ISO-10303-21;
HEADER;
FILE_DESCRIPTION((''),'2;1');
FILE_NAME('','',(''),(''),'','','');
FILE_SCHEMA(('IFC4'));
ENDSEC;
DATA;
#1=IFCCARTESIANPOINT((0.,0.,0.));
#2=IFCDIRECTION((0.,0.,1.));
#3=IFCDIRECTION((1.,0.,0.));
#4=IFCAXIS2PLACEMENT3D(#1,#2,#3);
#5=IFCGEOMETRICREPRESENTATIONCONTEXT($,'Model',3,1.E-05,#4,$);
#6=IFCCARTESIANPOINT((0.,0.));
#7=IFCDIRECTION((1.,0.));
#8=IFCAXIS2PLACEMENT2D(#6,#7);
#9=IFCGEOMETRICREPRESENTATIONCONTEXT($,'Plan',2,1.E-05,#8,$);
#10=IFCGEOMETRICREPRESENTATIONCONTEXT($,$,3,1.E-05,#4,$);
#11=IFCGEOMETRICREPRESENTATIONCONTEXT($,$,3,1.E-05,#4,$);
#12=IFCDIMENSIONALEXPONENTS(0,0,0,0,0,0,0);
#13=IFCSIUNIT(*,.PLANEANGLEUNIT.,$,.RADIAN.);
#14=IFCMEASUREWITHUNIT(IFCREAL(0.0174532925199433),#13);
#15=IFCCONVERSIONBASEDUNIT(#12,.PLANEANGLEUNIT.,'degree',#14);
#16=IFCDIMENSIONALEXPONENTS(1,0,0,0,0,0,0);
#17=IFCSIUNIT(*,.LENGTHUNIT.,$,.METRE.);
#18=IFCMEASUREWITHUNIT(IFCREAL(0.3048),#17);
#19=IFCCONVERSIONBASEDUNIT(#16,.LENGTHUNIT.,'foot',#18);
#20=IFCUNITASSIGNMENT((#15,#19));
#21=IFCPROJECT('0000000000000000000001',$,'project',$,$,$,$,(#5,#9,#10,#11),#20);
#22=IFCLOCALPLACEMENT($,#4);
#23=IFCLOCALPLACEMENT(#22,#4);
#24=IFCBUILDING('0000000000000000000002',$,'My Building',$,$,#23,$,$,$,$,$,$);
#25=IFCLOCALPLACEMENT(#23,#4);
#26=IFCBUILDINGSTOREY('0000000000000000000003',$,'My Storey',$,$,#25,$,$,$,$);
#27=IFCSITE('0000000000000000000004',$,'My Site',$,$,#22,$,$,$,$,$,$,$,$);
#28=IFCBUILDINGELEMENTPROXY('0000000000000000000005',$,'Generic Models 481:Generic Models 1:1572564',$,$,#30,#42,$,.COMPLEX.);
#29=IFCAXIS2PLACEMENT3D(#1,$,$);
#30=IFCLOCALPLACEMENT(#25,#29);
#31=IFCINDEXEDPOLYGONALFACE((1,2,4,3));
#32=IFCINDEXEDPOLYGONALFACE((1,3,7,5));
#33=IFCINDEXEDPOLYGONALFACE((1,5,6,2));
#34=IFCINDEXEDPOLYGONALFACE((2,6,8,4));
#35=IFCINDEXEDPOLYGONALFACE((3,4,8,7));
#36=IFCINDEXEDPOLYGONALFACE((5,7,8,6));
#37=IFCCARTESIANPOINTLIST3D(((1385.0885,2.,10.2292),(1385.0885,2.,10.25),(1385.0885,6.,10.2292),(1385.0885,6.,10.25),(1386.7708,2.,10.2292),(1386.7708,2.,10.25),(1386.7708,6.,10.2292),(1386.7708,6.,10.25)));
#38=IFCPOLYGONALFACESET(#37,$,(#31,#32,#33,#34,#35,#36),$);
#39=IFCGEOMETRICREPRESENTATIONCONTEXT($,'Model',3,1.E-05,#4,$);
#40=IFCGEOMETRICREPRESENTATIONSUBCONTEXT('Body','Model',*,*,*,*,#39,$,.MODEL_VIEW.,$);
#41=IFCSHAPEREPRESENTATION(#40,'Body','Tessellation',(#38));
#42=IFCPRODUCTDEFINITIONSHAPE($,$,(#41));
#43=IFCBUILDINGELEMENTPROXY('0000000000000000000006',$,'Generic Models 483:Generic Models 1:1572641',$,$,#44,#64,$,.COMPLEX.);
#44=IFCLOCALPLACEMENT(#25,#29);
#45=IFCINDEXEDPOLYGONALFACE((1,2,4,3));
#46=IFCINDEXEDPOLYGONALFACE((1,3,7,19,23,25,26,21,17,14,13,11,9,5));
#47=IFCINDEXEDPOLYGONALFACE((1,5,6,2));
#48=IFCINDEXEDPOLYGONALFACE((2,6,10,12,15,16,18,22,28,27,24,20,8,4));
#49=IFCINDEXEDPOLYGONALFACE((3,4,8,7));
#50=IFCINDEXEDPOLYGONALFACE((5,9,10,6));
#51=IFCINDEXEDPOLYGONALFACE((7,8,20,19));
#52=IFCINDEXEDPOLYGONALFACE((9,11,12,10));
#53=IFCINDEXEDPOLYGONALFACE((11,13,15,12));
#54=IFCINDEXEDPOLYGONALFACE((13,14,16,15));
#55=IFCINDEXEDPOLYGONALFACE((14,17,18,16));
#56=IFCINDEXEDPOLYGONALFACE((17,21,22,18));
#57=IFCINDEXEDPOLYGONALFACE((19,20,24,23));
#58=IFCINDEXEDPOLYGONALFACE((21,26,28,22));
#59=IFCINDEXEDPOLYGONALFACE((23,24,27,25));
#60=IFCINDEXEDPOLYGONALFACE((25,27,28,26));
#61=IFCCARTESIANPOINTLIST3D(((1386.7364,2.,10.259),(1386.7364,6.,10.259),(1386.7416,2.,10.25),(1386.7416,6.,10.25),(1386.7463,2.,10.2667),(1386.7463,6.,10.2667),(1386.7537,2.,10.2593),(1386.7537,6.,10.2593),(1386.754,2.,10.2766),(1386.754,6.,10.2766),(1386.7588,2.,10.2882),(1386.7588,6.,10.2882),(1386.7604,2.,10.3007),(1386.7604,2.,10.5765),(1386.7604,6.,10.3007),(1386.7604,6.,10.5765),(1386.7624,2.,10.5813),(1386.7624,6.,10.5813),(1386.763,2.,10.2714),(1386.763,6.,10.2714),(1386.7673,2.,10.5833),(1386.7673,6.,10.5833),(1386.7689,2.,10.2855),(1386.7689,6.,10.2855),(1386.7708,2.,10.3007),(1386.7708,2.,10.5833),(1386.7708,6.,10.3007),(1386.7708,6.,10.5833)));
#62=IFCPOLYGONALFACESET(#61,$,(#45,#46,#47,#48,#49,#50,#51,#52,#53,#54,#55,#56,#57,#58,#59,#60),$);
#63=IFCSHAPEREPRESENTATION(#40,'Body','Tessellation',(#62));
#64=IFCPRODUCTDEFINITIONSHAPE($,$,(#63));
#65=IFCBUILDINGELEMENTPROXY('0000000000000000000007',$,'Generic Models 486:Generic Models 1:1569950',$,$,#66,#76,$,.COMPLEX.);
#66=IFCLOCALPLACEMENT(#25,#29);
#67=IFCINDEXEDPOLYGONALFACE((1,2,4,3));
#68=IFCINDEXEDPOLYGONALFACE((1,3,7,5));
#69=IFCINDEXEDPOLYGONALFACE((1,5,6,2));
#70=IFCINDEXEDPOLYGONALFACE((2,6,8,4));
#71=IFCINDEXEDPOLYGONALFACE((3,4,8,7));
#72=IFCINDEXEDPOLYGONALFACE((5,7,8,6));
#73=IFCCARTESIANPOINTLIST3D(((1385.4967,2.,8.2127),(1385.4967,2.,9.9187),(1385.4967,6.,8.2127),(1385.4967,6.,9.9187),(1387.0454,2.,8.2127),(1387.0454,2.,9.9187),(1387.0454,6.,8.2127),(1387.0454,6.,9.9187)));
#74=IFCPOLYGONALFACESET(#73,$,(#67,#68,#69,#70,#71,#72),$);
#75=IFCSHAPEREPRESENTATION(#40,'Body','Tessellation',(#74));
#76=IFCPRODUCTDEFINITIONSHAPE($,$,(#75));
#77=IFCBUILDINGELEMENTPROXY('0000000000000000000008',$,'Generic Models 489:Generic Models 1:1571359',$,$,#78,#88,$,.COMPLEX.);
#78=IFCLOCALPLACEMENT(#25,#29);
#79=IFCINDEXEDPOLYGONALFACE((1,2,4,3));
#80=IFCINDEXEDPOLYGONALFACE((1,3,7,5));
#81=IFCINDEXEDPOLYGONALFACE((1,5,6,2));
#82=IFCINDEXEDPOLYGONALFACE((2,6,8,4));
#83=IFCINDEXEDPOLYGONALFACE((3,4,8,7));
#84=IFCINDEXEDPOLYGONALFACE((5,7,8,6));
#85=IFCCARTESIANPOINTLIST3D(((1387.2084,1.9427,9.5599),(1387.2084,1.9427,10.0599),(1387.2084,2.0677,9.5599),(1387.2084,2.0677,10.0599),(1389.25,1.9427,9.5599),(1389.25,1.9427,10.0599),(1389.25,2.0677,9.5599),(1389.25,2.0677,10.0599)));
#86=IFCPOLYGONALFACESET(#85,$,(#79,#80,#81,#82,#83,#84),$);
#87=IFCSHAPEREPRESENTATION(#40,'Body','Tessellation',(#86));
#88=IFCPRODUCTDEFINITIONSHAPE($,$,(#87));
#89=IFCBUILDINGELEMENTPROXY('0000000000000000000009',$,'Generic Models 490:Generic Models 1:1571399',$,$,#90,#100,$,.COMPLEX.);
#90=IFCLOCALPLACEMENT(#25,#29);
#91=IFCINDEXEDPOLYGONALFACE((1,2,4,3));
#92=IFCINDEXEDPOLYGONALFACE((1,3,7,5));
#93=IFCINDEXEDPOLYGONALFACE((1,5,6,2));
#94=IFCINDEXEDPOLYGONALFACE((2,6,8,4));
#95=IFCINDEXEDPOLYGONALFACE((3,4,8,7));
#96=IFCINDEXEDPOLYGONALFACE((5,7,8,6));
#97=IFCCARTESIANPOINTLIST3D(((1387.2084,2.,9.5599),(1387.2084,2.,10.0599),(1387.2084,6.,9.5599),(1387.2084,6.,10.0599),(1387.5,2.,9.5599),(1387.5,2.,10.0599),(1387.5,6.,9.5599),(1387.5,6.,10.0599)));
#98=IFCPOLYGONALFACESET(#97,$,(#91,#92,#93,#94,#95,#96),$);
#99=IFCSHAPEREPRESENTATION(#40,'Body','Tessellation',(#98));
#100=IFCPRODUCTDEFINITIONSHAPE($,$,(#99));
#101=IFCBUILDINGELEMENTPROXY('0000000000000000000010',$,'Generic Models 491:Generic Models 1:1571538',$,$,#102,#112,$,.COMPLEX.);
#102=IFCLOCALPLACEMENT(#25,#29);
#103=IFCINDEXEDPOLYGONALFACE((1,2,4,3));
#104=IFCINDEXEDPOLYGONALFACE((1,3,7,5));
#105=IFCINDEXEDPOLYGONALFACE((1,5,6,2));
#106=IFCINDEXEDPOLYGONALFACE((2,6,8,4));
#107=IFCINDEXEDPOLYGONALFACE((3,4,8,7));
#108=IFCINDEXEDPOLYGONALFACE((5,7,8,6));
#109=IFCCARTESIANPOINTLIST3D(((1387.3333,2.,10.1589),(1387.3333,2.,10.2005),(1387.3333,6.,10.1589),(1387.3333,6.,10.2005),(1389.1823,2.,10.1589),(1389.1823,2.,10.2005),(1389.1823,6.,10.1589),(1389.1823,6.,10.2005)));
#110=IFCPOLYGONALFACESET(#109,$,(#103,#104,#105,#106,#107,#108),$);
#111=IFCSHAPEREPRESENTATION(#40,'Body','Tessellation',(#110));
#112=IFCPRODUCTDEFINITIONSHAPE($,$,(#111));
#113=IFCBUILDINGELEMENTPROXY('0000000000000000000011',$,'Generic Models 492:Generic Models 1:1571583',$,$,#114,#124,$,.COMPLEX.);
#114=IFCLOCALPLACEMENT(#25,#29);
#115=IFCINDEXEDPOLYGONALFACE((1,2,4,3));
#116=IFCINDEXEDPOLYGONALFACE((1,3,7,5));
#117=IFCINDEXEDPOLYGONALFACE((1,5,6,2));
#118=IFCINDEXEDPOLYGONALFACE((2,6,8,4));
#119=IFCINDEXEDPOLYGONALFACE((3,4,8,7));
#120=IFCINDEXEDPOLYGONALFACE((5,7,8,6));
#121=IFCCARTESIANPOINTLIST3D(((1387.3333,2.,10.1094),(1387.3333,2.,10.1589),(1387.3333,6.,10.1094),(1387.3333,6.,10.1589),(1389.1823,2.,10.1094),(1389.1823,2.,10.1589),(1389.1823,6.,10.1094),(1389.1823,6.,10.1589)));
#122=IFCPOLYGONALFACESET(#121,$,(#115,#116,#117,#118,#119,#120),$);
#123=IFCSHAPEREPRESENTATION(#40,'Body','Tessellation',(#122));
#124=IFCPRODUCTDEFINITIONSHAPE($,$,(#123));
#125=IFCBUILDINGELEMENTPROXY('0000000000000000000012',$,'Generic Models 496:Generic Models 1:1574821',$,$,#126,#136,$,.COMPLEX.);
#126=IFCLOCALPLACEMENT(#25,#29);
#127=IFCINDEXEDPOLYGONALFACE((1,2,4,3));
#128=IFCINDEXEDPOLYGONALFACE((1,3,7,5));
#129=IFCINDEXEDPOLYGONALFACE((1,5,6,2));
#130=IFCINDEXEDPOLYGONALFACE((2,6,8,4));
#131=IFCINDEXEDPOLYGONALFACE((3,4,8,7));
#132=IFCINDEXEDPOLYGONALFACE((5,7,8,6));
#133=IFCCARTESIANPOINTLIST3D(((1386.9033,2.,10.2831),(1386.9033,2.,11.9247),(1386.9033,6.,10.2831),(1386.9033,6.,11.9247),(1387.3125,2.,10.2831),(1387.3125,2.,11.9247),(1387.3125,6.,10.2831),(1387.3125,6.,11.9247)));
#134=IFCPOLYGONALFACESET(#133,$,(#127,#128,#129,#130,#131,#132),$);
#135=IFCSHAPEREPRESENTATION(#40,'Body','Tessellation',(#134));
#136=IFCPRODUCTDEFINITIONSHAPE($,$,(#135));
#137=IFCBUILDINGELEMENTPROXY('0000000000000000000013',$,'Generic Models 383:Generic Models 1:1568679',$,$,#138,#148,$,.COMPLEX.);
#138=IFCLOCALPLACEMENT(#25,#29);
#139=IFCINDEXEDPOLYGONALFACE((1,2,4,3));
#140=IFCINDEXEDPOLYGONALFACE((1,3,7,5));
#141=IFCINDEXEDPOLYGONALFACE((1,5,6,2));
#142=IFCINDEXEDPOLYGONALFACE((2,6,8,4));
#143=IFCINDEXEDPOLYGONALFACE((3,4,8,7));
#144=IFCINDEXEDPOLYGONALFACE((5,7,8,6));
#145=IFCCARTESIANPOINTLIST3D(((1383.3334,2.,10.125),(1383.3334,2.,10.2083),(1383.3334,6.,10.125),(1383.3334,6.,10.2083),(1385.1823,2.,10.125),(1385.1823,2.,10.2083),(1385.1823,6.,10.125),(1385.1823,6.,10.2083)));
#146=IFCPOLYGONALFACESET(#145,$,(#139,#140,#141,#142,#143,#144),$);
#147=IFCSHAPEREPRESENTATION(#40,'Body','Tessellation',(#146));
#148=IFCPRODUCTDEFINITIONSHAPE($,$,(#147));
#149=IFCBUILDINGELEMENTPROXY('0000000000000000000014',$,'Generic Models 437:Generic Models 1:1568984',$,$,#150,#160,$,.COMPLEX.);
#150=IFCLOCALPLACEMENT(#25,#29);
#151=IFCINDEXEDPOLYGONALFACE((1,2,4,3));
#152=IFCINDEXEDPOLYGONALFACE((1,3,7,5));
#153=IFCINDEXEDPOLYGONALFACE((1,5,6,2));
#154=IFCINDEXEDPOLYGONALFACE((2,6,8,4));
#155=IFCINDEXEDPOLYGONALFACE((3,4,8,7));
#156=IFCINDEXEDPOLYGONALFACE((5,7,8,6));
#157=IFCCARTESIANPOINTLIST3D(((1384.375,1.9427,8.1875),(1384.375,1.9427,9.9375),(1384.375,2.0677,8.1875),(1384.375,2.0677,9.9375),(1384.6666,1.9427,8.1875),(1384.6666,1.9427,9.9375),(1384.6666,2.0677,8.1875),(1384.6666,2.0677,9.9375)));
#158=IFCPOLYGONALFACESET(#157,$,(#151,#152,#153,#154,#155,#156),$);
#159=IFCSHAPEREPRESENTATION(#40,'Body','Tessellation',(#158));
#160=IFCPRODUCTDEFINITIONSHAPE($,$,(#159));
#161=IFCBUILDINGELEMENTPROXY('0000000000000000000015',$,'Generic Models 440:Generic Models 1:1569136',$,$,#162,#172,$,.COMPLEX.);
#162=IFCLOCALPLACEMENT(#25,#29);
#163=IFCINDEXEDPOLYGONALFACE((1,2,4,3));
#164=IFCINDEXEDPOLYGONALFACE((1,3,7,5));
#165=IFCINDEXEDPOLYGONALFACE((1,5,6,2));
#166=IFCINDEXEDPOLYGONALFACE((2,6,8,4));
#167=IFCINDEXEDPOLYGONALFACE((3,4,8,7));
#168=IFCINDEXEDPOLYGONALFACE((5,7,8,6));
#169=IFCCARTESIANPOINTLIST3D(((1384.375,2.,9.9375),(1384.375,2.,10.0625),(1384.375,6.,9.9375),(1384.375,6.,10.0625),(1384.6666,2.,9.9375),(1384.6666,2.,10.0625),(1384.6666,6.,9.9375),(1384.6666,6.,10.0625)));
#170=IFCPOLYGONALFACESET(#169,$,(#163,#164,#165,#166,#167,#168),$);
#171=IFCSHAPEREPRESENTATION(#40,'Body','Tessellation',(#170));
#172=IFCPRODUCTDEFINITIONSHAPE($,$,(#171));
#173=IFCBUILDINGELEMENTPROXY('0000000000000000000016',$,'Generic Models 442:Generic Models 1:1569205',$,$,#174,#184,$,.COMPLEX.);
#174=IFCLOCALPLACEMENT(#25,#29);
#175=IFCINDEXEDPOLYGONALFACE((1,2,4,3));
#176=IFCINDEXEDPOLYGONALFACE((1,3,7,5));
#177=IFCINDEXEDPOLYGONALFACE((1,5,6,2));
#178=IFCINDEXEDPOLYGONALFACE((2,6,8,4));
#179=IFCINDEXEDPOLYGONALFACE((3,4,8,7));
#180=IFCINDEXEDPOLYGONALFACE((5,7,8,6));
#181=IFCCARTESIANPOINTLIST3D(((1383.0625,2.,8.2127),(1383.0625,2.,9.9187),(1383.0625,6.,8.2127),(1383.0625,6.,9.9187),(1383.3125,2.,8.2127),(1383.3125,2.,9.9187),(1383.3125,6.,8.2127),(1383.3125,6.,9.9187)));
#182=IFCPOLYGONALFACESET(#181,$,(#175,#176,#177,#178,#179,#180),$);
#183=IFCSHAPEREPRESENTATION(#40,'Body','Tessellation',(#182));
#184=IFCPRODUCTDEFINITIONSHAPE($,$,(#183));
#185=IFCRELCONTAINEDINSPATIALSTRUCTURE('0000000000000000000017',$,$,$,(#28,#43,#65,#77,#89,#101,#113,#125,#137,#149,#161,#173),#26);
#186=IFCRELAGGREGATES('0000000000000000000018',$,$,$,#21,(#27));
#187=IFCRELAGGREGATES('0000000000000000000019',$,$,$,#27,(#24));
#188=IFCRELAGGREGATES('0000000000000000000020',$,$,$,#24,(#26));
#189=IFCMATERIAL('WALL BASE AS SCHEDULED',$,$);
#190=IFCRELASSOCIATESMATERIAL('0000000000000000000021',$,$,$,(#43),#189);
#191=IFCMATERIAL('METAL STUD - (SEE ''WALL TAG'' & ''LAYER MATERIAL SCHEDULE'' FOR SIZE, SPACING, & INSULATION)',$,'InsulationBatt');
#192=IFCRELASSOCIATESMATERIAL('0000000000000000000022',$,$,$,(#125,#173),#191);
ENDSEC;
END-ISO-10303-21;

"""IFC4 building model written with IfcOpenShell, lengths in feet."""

from ifc_helpers import new_model, entity, si_unit, converted_unit, frame, origin_with_axes, origin_2d_with_axis, place, context, subcontext, project, spatial, polyline, outline, extrude, material, element, save


model = new_model("IFC4")

# Units and contexts
model_context_1 = context("Model", 3, precision=1e-05, world=origin_with_axes())
plan_context = context("Plan", 2, precision=1e-05, world=origin_2d_with_axis())
model_context_2 = context("Model", 3, precision=1e-05, world=origin_with_axes())
context_of_model_1 = context(None, 3, precision=1e-05, world=origin_with_axes())
context_of_model_2 = context(None, 3, precision=1e-05, world=origin_with_axes())
body_context = subcontext(model_context_2, "Body", "Model", "MODEL_VIEW")
ifc_project = project(units=[converted_unit("PLANEANGLEUNIT", "degree", entity("IfcReal", 0.0174532925199433), si_unit("PLANEANGLEUNIT", "RADIAN"), dimensions=[0, 0, 0, 0, 0, 0, 0]), converted_unit("LENGTHUNIT", "foot", entity("IfcReal", 0.3048), si_unit("LENGTHUNIT", "METRE"), dimensions=[1, 0, 0, 0, 0, 0, 0])], contexts=[model_context_1, plan_context, context_of_model_1, context_of_model_2])

# Site, building, storey
site_placement = place(None, origin_with_axes())
site = spatial("IfcSite", under=ifc_project, at=site_placement, Name="My Site")
building_placement = place(site_placement, origin_with_axes())
building = spatial("IfcBuilding", under=site, at=building_placement, Name="My Building")
storey_placement = place(building_placement, origin_with_axes())
storey = spatial("IfcBuildingStorey", under=building, at=storey_placement, Name="My Storey")

# Building element proxies
proxy_1_placement = place(storey_placement, frame((1385.0885, 6.0, 10.2292), z_axis=(0.0, -1.0, 0.0), x_axis=(0.0, 0.0, 1.0)))
element("IfcBuildingElementProxy", 1, at=proxy_1_placement, inside=storey, Name="Generic Models 481:Generic Models 1:1572564", PredefinedType="COMPLEX", context=body_context, shape_type="SweptSolid", body=[
    extrude(outline(polyline([(0.8412, 0.0), (0.841, 0.0208), (-0.8412, 0.0), (-0.841, -0.0208), (0.8412, 0.0)])), frame((0.0104, -0.8411, 0.0), z_axis=(0.0, 0.0, -1.0), x_axis=(0.012383, -0.999923, 0.0)), (0.0, 0.0, -1.0), 4.0),
])
ifc_material_1 = material(Name="WALL BASE AS SCHEDULED")
proxy_2_placement = place(storey_placement, frame((1386.7364, 6.0, 10.25), z_axis=(0.0, -1.0, 0.0), x_axis=(0.0, 0.0, 1.0)))
element("IfcBuildingElementProxy", 2, at=proxy_2_placement, inside=storey, material=ifc_material_1, Name="Generic Models 483:Generic Models 1:1572641", PredefinedType="COMPLEX", context=body_context, shape_type="SweptSolid", body=[
    extrude(outline(polyline([(0.2205, 0.0), (0.2206, 0.0036), (-0.0618, 0.0152), (-0.077, 0.0138), (-0.0914, 0.0086), (-0.1038, -0.0002), (-0.1136, -0.012), (-0.1048, -0.0175), (-0.0968, -0.0079), (-0.0865, -0.0007), (-0.0747, 0.0037), (-0.0622, 0.0048), (0.2133, -0.0066), (0.2183, -0.0048), (0.2205, 0.0)])), frame((0.113, -0.0218, 0.0), z_axis=(0.0, 0.0, -1.0), x_axis=(0.999153, -0.041137, 0.0)), (0.0, 0.0, -1.0), 4.0),
])
proxy_3_placement = place(storey_placement, frame((1385.4967, 6.0, 8.2127), z_axis=(0.0, -1.0, 0.0), x_axis=(0.0, 0.0, 1.0)))
element("IfcBuildingElementProxy", 3, at=proxy_3_placement, inside=storey, Name="Generic Models 486:Generic Models 1:1569950", PredefinedType="COMPLEX", context=body_context, shape_type="SweptSolid", body=[
    extrude(outline(polyline([(-0.853, -0.7743), (0.853, -0.7743), (0.853, 0.7743), (-0.853, 0.7743), (-0.853, -0.7743)])), frame((0.853, -0.7743, 0.0), z_axis=(0.0, 0.0, -1.0), x_axis=(-1.0, 0.0, 0.0)), (0.0, 0.0, -1.0), 4.0),
])
proxy_4_placement = place(storey_placement, frame((1387.2084, 1.9427, 9.5599), z_axis=(1.0, 0.0, 0.0), x_axis=(0.0, 0.0, -1.0)))
element("IfcBuildingElementProxy", 4, at=proxy_4_placement, inside=storey, Name="Generic Models 489:Generic Models 1:1571359", PredefinedType="COMPLEX", context=body_context, shape_type="SweptSolid", body=[
    extrude(outline(polyline([(-0.0625, -0.25), (0.0625, -0.25), (0.0625, 0.25), (-0.0625, 0.25), (-0.0625, -0.25)])), frame((-0.25, 0.0625, 0.0), z_axis=(0.0, 0.0, -1.0), x_axis=(0.0, -1.0, 0.0)), (0.0, 0.0, -1.0), 2.0417),
])
proxy_5_placement = place(storey_placement, frame((1387.2084, 6.0, 9.5599), z_axis=(0.0, -1.0, 0.0), x_axis=(0.0, 0.0, 1.0)))
element("IfcBuildingElementProxy", 5, at=proxy_5_placement, inside=storey, Name="Generic Models 490:Generic Models 1:1571399", PredefinedType="COMPLEX", context=body_context, shape_type="SweptSolid", body=[
    extrude(outline(polyline([(-0.25, -0.1458), (0.25, -0.1458), (0.25, 0.1458), (-0.25, 0.1458), (-0.25, -0.1458)])), frame((0.25, -0.1458, 0.0), z_axis=(0.0, 0.0, -1.0), x_axis=(-1.0, 0.0, 0.0)), (0.0, 0.0, -1.0), 4.0),
])
proxy_6_placement = place(storey_placement, frame((1387.3333, 6.0, 10.1589), z_axis=(0.0, -1.0, 0.0), x_axis=(0.0, 0.0, 1.0)))
element("IfcBuildingElementProxy", 6, at=proxy_6_placement, inside=storey, Name="Generic Models 491:Generic Models 1:1571538", PredefinedType="COMPLEX", context=body_context, shape_type="SweptSolid", body=[
    extrude(outline(polyline([(-0.0208, -0.9245), (0.0208, -0.9245), (0.0208, 0.9245), (-0.0208, 0.9245), (-0.0208, -0.9245)])), frame((0.0208, -0.9245, 0.0), z_axis=(0.0, 0.0, -1.0), x_axis=(-1.0, 0.0, 0.0)), (0.0, 0.0, -1.0), 4.0),
])
proxy_7_placement = place(storey_placement, frame((1387.3333, 6.0, 10.1094), z_axis=(0.0, -1.0, 0.0), x_axis=(0.0, 0.0, 1.0)))
element("IfcBuildingElementProxy", 7, at=proxy_7_placement, inside=storey, Name="Generic Models 492:Generic Models 1:1571583", PredefinedType="COMPLEX", context=body_context, shape_type="SweptSolid", body=[
    extrude(outline(polyline([(-0.0247, -0.9245), (0.0247, -0.9245), (0.0247, 0.9245), (-0.0247, 0.9245), (-0.0247, -0.9245)])), frame((0.0247, -0.9245, 0.0), z_axis=(0.0, 0.0, -1.0), x_axis=(-1.0, 0.0, 0.0)), (0.0, 0.0, -1.0), 4.0),
])
ifc_material_2 = material(Name="METAL STUD - (SEE 'WALL TAG' & 'LAYER MATERIAL SCHEDULE' FOR SIZE, SPACING, & INSULATION)", Category="InsulationBatt")
proxy_8_placement = place(storey_placement, frame((1386.9033, 6.0, 10.2831), z_axis=(0.0, -1.0, 0.0), x_axis=(0.0, 0.0, 1.0)))
element("IfcBuildingElementProxy", 8, at=proxy_8_placement, inside=storey, material=ifc_material_2, Name="Generic Models 496:Generic Models 1:1574821", PredefinedType="COMPLEX", context=body_context, shape_type="SweptSolid", body=[
    extrude(outline(polyline([(-0.8208, -0.2046), (0.8208, -0.2046), (0.8208, 0.2046), (-0.8208, 0.2046), (-0.8208, -0.2046)])), frame((0.8208, -0.2046, 0.0), z_axis=(0.0, 0.0, -1.0), x_axis=(1.0, 0.0, 0.0)), (0.0, 0.0, -1.0), 4.0),
])
proxy_9_placement = place(storey_placement, frame((1383.3334, 6.0, 10.125), z_axis=(0.0, -1.0, 0.0), x_axis=(0.0, 0.0, 1.0)))
element("IfcBuildingElementProxy", 9, at=proxy_9_placement, inside=storey, Name="Generic Models 383:Generic Models 1:1568679", PredefinedType="COMPLEX", context=body_context, shape_type="SweptSolid", body=[
    extrude(outline(polyline([(-0.0417, -0.9245), (0.0417, -0.9245), (0.0417, 0.9245), (-0.0417, 0.9245), (-0.0417, -0.9245)])), frame((0.0417, -0.9245, 0.0), z_axis=(0.0, 0.0, -1.0), x_axis=(-1.0, 0.0, 0.0)), (0.0, 0.0, -1.0), 4.0),
])
proxy_10_placement = place(storey_placement, frame((1384.375, 1.9427, 8.1875), z_axis=(0.0, 0.0, 1.0), x_axis=(1.0, 0.0, 0.0)))
element("IfcBuildingElementProxy", 10, at=proxy_10_placement, inside=storey, Name="Generic Models 437:Generic Models 1:1568984", PredefinedType="COMPLEX", context=body_context, shape_type="SweptSolid", body=[
    extrude(outline(polyline([(-0.1458, -0.0625), (0.1458, -0.0625), (0.1458, 0.0625), (-0.1458, 0.0625), (-0.1458, -0.0625)])), frame((0.1458, 0.0625, 0.0), z_axis=(0.0, 0.0, -1.0), x_axis=(-1.0, 0.0, 0.0)), (0.0, 0.0, -1.0), 1.75),
])
proxy_11_placement = place(storey_placement, frame((1384.375, 6.0, 9.9375), z_axis=(0.0, -1.0, 0.0), x_axis=(0.0, 0.0, 1.0)))
element("IfcBuildingElementProxy", 11, at=proxy_11_placement, inside=storey, Name="Generic Models 440:Generic Models 1:1569136", PredefinedType="COMPLEX", context=body_context, shape_type="SweptSolid", body=[
    extrude(outline(polyline([(-0.1458, -0.0625), (0.1458, -0.0625), (0.1458, 0.0625), (-0.1458, 0.0625), (-0.1458, -0.0625)])), frame((0.0625, -0.1458, 0.0), z_axis=(0.0, 0.0, -1.0), x_axis=(0.0, 1.0, 0.0)), (0.0, 0.0, -1.0), 4.0),
])
proxy_12_placement = place(storey_placement, frame((1383.0625, 6.0, 8.2127), z_axis=(0.0, -1.0, 0.0), x_axis=(0.0, 0.0, 1.0)))
element("IfcBuildingElementProxy", 12, at=proxy_12_placement, inside=storey, material=ifc_material_2, Name="Generic Models 442:Generic Models 1:1569205", PredefinedType="COMPLEX", context=body_context, shape_type="SweptSolid", body=[
    extrude(outline(polyline([(-0.125, -0.853), (0.125, -0.853), (0.125, 0.853), (-0.125, 0.853), (-0.125, -0.853)])), frame((0.853, -0.125, 0.0), z_axis=(0.0, 0.0, -1.0), x_axis=(0.0, 1.0, 0.0)), (0.0, 0.0, -1.0), 4.0),
])

save(model, "model.ifc")
